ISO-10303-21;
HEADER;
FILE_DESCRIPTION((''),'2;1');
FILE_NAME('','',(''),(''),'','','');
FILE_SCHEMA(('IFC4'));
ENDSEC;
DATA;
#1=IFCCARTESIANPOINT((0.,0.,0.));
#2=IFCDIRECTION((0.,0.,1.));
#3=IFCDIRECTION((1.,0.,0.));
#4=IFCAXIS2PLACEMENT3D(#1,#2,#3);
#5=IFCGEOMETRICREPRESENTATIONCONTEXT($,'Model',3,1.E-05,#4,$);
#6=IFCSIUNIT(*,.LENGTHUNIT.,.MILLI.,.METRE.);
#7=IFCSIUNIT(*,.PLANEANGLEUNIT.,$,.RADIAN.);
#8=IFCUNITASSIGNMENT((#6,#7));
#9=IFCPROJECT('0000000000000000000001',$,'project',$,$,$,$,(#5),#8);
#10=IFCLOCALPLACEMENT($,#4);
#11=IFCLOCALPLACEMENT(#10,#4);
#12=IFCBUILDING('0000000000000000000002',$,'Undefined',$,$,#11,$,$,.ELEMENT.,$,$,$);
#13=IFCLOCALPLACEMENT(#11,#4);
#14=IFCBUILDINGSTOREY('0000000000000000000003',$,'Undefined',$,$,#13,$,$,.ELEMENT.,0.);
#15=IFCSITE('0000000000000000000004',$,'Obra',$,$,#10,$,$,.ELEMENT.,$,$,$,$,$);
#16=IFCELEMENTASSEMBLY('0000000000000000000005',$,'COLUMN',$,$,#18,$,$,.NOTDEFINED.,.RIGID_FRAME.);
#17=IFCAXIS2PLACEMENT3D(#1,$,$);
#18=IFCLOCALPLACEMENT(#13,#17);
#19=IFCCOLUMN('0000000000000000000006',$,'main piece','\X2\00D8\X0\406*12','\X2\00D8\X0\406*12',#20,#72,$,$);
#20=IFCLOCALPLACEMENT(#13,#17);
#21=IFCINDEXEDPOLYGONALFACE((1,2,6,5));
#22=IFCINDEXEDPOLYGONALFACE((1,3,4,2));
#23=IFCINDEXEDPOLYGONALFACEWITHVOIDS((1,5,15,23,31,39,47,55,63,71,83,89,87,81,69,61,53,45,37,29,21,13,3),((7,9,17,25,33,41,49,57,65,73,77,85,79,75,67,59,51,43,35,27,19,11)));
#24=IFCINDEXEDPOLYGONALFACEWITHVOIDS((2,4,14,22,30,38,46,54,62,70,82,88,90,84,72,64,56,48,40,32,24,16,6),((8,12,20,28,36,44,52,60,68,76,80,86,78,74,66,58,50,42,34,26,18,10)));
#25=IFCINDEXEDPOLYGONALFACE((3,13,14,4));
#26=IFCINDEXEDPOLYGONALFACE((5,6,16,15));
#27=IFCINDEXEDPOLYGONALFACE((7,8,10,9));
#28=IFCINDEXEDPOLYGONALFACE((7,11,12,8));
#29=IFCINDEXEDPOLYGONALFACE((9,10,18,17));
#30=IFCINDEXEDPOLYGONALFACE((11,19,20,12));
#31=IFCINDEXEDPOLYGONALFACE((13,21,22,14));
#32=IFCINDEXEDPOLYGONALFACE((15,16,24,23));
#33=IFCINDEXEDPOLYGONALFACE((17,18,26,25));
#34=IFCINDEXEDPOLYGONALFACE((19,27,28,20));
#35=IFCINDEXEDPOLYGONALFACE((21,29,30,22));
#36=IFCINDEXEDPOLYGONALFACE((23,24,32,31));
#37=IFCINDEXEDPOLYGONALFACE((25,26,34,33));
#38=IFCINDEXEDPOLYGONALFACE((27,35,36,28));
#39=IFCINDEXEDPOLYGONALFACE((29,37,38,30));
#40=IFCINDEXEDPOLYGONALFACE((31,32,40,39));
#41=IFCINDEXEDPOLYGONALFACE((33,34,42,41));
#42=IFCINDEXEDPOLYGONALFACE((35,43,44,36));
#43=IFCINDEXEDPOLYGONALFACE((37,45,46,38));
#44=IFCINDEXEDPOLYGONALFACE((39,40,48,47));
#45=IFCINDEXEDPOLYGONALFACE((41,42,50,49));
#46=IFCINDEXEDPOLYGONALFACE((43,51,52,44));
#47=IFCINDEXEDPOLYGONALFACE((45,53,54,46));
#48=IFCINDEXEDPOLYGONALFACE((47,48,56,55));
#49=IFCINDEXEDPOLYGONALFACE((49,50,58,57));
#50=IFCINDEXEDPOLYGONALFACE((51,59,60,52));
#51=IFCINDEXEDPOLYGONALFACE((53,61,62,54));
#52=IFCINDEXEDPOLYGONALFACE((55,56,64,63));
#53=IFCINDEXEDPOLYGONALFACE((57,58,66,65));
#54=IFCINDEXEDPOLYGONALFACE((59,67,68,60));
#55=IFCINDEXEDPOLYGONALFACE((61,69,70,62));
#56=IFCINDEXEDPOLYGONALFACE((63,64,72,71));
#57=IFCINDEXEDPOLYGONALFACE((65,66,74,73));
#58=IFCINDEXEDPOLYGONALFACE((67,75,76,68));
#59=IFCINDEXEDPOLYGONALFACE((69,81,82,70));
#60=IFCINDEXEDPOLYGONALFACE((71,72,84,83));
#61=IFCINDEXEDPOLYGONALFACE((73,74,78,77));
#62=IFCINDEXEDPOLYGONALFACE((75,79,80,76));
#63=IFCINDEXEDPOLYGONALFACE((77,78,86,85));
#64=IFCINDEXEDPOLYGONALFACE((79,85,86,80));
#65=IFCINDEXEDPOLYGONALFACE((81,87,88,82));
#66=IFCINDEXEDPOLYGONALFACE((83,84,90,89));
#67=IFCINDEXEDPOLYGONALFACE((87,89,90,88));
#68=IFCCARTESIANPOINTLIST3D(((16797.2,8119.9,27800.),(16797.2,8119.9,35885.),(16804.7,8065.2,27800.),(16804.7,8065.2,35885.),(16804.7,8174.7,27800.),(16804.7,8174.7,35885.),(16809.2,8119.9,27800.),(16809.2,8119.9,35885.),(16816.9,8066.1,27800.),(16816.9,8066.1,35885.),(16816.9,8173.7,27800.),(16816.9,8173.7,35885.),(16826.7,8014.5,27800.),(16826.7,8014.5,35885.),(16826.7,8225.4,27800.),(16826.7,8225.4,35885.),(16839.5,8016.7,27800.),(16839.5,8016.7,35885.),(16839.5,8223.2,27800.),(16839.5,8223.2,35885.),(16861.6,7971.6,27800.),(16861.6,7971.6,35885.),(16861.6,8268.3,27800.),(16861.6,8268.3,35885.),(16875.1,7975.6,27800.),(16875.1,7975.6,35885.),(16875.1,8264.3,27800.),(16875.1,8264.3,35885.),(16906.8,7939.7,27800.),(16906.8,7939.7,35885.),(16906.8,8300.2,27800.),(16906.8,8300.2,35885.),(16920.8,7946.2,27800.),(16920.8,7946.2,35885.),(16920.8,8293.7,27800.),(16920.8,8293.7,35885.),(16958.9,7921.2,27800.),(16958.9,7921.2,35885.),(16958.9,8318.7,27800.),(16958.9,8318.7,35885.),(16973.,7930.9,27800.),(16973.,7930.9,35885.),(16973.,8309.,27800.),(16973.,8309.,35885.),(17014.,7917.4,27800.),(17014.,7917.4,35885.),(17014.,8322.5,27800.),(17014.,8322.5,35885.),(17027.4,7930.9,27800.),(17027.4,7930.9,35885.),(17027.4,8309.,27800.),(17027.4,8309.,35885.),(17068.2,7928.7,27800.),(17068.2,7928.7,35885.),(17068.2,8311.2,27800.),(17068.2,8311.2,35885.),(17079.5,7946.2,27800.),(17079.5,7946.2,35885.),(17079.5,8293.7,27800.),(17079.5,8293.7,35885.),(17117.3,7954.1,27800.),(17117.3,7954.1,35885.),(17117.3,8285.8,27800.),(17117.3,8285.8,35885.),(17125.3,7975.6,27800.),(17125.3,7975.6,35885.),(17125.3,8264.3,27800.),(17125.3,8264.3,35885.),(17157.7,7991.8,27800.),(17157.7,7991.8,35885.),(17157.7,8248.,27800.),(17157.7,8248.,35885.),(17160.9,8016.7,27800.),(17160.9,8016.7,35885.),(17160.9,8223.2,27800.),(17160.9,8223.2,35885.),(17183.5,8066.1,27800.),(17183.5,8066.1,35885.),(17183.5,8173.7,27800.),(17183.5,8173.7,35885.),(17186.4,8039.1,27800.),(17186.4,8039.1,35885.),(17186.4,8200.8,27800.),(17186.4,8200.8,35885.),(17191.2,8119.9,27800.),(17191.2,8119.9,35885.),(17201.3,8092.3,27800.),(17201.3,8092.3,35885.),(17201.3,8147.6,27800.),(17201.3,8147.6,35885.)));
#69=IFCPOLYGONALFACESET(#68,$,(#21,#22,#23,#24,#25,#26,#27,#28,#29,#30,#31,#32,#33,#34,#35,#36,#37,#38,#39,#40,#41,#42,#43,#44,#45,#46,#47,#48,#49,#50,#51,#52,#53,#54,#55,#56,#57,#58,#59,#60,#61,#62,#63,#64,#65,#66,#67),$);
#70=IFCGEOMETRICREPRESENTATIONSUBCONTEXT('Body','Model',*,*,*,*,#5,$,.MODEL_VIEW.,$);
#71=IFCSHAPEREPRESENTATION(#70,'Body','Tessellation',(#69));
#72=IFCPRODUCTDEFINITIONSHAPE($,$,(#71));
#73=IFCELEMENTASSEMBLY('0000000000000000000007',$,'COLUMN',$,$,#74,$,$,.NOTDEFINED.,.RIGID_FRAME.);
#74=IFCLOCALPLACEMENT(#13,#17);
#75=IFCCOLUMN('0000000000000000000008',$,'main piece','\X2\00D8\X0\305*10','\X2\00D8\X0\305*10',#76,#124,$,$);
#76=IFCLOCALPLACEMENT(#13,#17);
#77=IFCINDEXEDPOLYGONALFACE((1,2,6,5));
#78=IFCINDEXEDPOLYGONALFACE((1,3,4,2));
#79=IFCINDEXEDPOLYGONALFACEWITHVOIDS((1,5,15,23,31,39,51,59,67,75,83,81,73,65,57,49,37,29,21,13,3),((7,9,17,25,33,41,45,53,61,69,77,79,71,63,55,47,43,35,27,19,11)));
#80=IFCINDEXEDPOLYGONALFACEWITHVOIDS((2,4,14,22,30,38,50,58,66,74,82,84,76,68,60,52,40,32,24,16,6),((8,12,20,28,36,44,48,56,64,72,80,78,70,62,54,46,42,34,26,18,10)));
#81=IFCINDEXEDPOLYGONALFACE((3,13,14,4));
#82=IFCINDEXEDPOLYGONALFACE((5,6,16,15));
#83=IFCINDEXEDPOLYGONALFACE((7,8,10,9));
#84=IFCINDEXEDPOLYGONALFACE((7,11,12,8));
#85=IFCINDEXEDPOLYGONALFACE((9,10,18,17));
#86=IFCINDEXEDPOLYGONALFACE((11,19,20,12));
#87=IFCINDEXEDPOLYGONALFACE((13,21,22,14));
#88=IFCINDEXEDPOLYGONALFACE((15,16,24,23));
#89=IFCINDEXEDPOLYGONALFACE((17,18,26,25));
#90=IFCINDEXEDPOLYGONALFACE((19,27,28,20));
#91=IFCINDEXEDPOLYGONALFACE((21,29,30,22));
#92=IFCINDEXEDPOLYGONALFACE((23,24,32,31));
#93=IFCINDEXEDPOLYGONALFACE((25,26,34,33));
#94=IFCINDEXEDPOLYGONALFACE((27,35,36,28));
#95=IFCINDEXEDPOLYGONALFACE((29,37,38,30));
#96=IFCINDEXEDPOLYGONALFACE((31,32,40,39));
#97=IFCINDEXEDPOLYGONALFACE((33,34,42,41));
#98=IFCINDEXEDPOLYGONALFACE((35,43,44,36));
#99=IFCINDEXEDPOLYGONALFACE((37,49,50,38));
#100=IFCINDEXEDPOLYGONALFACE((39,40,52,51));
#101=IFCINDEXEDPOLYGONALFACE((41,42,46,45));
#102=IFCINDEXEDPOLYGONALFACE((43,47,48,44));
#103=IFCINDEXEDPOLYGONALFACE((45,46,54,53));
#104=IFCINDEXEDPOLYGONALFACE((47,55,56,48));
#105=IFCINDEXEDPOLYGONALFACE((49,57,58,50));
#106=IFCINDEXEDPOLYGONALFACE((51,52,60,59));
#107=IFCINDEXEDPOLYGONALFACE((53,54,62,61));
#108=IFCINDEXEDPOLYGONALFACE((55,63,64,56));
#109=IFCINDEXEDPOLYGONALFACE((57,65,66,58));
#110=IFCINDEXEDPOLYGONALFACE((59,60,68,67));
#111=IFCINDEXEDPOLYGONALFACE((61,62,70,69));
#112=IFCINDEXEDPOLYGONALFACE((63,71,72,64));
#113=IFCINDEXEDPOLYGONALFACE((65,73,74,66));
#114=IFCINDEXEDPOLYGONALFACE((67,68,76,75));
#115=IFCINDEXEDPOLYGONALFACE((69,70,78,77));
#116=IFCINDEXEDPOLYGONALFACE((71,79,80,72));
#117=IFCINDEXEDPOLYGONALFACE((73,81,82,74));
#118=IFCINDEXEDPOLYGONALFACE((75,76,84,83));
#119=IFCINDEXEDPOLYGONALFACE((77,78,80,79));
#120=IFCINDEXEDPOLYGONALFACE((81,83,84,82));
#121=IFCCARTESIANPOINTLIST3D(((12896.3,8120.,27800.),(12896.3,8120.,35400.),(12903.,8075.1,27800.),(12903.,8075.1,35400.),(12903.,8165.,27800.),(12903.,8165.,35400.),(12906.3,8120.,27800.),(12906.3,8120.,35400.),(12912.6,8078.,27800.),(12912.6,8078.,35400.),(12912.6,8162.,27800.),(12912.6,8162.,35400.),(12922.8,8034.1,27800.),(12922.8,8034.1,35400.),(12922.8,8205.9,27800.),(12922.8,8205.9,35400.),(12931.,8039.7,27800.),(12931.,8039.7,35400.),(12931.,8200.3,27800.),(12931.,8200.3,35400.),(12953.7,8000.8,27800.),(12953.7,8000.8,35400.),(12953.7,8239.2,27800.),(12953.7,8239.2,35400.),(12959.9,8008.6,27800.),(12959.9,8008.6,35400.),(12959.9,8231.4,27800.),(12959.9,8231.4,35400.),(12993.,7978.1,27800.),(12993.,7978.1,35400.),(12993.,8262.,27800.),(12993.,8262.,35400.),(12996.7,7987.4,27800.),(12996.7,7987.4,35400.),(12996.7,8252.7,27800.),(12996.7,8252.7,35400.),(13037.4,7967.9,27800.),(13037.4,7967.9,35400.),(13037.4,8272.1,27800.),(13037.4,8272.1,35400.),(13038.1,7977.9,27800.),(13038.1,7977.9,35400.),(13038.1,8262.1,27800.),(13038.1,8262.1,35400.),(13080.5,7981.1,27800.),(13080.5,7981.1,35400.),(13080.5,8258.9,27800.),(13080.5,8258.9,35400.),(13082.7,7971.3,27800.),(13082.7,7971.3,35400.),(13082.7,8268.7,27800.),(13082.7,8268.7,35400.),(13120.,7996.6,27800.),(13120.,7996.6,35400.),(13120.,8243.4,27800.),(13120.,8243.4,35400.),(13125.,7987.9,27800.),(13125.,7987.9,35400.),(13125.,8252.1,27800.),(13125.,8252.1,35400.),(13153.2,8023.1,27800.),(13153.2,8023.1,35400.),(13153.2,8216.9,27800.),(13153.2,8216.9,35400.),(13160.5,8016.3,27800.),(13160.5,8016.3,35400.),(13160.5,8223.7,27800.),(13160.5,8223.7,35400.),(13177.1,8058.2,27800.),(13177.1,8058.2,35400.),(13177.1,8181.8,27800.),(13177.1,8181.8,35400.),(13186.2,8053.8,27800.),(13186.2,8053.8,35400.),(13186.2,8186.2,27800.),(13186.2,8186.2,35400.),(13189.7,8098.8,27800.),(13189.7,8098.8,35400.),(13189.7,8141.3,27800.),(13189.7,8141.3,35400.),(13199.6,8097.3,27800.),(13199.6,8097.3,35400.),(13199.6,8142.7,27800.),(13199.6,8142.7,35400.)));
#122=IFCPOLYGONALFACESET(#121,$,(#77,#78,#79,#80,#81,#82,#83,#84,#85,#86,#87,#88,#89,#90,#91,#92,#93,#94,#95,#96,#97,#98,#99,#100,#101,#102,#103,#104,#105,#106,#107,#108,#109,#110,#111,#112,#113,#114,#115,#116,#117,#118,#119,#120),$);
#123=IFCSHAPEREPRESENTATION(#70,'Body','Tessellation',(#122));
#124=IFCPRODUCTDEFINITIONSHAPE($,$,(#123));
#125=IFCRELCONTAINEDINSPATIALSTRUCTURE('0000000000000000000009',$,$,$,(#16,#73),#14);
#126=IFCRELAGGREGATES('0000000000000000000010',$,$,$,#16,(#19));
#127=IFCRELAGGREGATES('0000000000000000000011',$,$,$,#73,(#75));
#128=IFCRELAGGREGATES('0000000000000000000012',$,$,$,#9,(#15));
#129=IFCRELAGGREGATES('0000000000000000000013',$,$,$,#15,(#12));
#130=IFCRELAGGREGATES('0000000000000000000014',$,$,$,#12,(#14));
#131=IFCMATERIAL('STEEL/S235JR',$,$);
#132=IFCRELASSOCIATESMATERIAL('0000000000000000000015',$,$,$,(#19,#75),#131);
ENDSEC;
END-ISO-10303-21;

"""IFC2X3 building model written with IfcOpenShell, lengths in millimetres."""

from ifc_helpers import new_model, si_unit, frame, origin_with_axes, origin_2d_with_axis, place, context, subcontext, project, spatial, hollow_circle, extrude, clip, halfspace, material, element, aggregate, save


model = new_model("IFC2X3")

# Units and contexts
model_context = context("Model", 3, precision=1e-05, world=origin_with_axes())
body_context = subcontext(model_context, "Body", "Model", "MODEL_VIEW")
ifc_project = project(units=[si_unit("LENGTHUNIT", "METRE", prefix="MILLI"), si_unit("PLANEANGLEUNIT", "RADIAN")], contexts=[model_context])

# Site, building, storey
site_placement = place(None, origin_with_axes())
site = spatial("IfcSite", under=ifc_project, at=site_placement, Name="Obra", CompositionType="ELEMENT")
building_placement = place(site_placement, origin_with_axes())
building = spatial("IfcBuilding", under=site, at=building_placement, Name="Undefined", CompositionType="ELEMENT")
storey_placement = place(building_placement, origin_with_axes())
storey = spatial("IfcBuildingStorey", under=building, at=storey_placement, Name="Undefined", CompositionType="ELEMENT", Elevation=0.0)

# Element assemblies, columns
assembly_1_placement = place(storey_placement, origin_with_axes())
assembly_1 = element("IfcElementAssembly", 1, at=assembly_1_placement, inside=storey, Name="COLUMN", AssemblyPlace="NOTDEFINED", PredefinedType="RIGID_FRAME")
ifc_material_1 = material(Name="STEEL/S235JR")
column_1_placement = place(assembly_1_placement, frame((17000.2, 8119.9, 27800.0), z_axis=(0.0, 0.0, 1.0), x_axis=(0.0, 1.0, 0.0)))
column_1 = element("IfcColumn", 2, at=column_1_placement, material=ifc_material_1, Name="main piece", Description="Ø406*12", ObjectType="Ø406*12", context=body_context, shape_type="Clipping", body=[
    clip(extrude(hollow_circle(Radius=203.0, WallThickness=12.0, at=origin_2d_with_axis()), frame((0.0, 0.0, 8085.0), z_axis=(0.0, 0.0, -1.0), x_axis=(0.0, 1.0, 0.0)), (0.0, 0.0, 1.0), 8085.0), halfspace(frame((-203.0, 0.0, 8085.0), z_axis=(0.0, 0.0, -1.0), x_axis=(0.0, -1.0, 0.0)), True)),
])
assembly_2_placement = place(storey_placement, origin_with_axes())
assembly_2 = element("IfcElementAssembly", 3, at=assembly_2_placement, inside=storey, Name="COLUMN", AssemblyPlace="NOTDEFINED", PredefinedType="RIGID_FRAME")
column_2_placement = place(assembly_2_placement, frame((13048.8, 8120.0, 27800.0), z_axis=(0.0, 0.0, 1.0), x_axis=(0.0, 1.0, 0.0)))
column_2 = element("IfcColumn", 4, at=column_2_placement, material=ifc_material_1, Name="main piece", Description="Ø305*10", ObjectType="Ø305*10", context=body_context, shape_type="SweptSolid", body=[
    extrude(hollow_circle(Radius=152.5, WallThickness=10.0, at=origin_2d_with_axis()), frame((0.0, 0.0, 7600.0), z_axis=(0.0, 0.0, -1.0), x_axis=(0.0, 1.0, 0.0)), (0.0, 0.0, 1.0), 7600.0),
])

aggregate(assembly_1, [column_1])
aggregate(assembly_2, [column_2])

save(model, "model.ifc")
